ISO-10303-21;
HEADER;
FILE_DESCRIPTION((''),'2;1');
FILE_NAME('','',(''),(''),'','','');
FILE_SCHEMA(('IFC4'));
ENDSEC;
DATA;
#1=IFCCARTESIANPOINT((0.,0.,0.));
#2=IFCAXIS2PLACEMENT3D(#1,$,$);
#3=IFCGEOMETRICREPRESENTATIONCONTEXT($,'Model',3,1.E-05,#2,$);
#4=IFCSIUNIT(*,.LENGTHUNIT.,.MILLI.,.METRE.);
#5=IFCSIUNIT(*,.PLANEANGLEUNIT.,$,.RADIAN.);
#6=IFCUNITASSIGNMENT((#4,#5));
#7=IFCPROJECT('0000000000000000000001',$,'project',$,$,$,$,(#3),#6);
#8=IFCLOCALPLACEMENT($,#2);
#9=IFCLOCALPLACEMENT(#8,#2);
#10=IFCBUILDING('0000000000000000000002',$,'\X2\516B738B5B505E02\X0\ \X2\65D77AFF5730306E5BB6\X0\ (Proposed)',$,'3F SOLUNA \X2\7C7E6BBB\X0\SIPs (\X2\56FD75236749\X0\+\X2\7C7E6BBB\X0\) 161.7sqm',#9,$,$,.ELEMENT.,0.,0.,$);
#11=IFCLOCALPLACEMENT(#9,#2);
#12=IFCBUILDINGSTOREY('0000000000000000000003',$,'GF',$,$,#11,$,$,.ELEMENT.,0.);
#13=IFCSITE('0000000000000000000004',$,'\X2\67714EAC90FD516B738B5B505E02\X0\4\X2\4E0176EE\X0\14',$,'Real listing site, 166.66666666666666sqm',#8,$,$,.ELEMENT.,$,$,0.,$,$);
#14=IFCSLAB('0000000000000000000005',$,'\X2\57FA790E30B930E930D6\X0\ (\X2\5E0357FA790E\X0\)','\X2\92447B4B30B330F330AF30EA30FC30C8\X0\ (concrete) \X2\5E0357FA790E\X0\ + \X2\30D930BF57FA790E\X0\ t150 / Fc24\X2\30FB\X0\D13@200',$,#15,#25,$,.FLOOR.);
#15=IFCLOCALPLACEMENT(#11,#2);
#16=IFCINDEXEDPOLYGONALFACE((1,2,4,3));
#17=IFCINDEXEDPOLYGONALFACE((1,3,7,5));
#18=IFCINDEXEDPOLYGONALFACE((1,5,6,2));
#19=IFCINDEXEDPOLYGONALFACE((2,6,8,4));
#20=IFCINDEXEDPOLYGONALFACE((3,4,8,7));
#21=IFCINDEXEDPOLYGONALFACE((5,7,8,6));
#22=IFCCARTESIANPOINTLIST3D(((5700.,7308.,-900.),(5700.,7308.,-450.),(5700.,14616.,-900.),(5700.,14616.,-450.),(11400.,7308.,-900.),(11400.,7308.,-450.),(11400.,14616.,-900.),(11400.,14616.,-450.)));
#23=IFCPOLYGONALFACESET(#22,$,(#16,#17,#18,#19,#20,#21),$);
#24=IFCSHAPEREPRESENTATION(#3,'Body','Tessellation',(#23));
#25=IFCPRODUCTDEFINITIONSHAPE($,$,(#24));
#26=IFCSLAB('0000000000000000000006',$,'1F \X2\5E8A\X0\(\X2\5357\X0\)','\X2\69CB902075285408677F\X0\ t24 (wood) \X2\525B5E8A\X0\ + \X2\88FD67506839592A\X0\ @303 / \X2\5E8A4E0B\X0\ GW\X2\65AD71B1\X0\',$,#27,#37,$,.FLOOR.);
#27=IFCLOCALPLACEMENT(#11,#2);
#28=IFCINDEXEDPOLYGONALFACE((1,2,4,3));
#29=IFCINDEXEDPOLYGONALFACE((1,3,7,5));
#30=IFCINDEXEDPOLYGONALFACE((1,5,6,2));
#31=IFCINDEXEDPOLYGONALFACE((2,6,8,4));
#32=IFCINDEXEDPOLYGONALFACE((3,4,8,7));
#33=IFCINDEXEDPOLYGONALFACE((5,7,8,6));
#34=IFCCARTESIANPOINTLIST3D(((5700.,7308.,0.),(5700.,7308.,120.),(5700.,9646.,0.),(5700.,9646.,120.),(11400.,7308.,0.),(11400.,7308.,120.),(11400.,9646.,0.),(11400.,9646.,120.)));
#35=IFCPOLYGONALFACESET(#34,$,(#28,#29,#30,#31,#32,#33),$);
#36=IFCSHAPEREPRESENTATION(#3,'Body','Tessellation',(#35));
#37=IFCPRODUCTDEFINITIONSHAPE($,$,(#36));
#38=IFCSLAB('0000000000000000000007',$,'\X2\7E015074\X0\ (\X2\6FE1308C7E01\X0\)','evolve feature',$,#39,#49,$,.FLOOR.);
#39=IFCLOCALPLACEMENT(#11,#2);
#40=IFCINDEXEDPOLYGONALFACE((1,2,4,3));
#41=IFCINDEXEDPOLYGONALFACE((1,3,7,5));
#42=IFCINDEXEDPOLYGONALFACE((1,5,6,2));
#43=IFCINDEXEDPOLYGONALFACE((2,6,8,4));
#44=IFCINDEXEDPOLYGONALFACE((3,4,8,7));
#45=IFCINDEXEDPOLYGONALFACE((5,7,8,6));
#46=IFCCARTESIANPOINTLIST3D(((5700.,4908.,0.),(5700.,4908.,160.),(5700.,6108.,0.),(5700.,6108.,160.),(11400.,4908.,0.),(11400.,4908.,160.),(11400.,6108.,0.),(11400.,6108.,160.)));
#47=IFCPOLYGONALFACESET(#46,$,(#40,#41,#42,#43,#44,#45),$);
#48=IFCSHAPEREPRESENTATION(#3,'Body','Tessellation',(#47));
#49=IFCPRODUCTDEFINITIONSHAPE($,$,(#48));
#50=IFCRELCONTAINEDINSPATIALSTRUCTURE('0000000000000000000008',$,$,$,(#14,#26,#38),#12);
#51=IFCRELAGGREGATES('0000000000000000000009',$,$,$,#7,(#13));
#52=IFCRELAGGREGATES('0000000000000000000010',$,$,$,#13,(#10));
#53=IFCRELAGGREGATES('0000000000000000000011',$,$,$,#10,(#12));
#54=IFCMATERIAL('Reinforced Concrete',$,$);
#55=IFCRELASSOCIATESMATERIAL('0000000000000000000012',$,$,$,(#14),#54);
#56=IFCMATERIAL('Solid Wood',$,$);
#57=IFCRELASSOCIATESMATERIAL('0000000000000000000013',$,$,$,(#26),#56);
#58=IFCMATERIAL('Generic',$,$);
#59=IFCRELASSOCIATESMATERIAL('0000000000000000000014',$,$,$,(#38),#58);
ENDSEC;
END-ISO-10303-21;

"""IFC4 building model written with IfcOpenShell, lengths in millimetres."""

from ifc_helpers import new_model, si_unit, frame, frame_2d, origin, place, context, project, spatial, rectangle, extrude, material, element, save


model = new_model("IFC4")

# Units and contexts
model_context = context("Model", 3, precision=1e-05, world=origin())
ifc_project = project(units=[si_unit("LENGTHUNIT", "METRE", prefix="MILLI"), si_unit("PLANEANGLEUNIT", "RADIAN")], contexts=[model_context])

# Site, building, storey
site_placement = place(None, origin())
site = spatial("IfcSite", under=ifc_project, at=site_placement, Name="東京都八王子市4丁目14", ObjectType="Real listing site, 166.66666666666666sqm", CompositionType="ELEMENT", RefElevation=0.0)
building_placement = place(site_placement, origin())
building = spatial("IfcBuilding", under=site, at=building_placement, Name="八王子市 旗竿地の家 (Proposed)", ObjectType="3F SOLUNA 籾殻SIPs (国産杉+籾殻) 161.7sqm", CompositionType="ELEMENT", ElevationOfRefHeight=0.0, ElevationOfTerrain=0.0)
storey_placement = place(building_placement, origin())
storey = spatial("IfcBuildingStorey", under=building, at=storey_placement, Name="GF", CompositionType="ELEMENT", Elevation=0.0)

# Slabs
ifc_material_1 = material(Name="Reinforced Concrete")
slab_1_placement = place(storey_placement, frame((2850.0, 3654.0, -450.0)))
element("IfcSlab", 1, at=slab_1_placement, inside=storey, material=ifc_material_1, Name="基礎スラブ (布基礎)", Description="鉄筋コンクリート (concrete) 布基礎 + ベタ基礎 t150 / Fc24・D13@200", PredefinedType="FLOOR", context=model_context, shape_type="SweptSolid", body=[
    extrude(rectangle(XDim=5700.0, YDim=7308.0, at=frame_2d((2850.0, 3654.0))), frame((2850.0, 3654.0, -450.0)), (0.0, 0.0, 1.0), 450.0),
])
ifc_material_2 = material(Name="Solid Wood")
slab_2_placement = place(storey_placement, frame((2850.0, 3654.0, 0.0)))
element("IfcSlab", 2, at=slab_2_placement, inside=storey, material=ifc_material_2, Name="1F 床(南)", Description="構造用合板 t24 (wood) 剛床 + 製材根太 @303 / 床下 GW断熱", PredefinedType="FLOOR", context=model_context, shape_type="SweptSolid", body=[
    extrude(rectangle(XDim=5700.0, YDim=2338.0, at=frame_2d((2850.0, 1169.0))), frame((2850.0, 3654.0, 0.0)), (0.0, 0.0, 1.0), 120.0),
])
ifc_material_3 = material(Name="Generic")
slab_3_placement = place(storey_placement, frame((2850.0, 2454.0, 0.0)))
element("IfcSlab", 3, at=slab_3_placement, inside=storey, material=ifc_material_3, Name="縁側 (濡れ縁)", Description="evolve feature", PredefinedType="FLOOR", context=model_context, shape_type="SweptSolid", body=[
    extrude(rectangle(XDim=5700.0, YDim=1200.0, at=frame_2d((2850.0, 600.0))), frame((2850.0, 2454.0, 0.0)), (0.0, 0.0, 1.0), 160.0),
])

save(model, "model.ifc")
